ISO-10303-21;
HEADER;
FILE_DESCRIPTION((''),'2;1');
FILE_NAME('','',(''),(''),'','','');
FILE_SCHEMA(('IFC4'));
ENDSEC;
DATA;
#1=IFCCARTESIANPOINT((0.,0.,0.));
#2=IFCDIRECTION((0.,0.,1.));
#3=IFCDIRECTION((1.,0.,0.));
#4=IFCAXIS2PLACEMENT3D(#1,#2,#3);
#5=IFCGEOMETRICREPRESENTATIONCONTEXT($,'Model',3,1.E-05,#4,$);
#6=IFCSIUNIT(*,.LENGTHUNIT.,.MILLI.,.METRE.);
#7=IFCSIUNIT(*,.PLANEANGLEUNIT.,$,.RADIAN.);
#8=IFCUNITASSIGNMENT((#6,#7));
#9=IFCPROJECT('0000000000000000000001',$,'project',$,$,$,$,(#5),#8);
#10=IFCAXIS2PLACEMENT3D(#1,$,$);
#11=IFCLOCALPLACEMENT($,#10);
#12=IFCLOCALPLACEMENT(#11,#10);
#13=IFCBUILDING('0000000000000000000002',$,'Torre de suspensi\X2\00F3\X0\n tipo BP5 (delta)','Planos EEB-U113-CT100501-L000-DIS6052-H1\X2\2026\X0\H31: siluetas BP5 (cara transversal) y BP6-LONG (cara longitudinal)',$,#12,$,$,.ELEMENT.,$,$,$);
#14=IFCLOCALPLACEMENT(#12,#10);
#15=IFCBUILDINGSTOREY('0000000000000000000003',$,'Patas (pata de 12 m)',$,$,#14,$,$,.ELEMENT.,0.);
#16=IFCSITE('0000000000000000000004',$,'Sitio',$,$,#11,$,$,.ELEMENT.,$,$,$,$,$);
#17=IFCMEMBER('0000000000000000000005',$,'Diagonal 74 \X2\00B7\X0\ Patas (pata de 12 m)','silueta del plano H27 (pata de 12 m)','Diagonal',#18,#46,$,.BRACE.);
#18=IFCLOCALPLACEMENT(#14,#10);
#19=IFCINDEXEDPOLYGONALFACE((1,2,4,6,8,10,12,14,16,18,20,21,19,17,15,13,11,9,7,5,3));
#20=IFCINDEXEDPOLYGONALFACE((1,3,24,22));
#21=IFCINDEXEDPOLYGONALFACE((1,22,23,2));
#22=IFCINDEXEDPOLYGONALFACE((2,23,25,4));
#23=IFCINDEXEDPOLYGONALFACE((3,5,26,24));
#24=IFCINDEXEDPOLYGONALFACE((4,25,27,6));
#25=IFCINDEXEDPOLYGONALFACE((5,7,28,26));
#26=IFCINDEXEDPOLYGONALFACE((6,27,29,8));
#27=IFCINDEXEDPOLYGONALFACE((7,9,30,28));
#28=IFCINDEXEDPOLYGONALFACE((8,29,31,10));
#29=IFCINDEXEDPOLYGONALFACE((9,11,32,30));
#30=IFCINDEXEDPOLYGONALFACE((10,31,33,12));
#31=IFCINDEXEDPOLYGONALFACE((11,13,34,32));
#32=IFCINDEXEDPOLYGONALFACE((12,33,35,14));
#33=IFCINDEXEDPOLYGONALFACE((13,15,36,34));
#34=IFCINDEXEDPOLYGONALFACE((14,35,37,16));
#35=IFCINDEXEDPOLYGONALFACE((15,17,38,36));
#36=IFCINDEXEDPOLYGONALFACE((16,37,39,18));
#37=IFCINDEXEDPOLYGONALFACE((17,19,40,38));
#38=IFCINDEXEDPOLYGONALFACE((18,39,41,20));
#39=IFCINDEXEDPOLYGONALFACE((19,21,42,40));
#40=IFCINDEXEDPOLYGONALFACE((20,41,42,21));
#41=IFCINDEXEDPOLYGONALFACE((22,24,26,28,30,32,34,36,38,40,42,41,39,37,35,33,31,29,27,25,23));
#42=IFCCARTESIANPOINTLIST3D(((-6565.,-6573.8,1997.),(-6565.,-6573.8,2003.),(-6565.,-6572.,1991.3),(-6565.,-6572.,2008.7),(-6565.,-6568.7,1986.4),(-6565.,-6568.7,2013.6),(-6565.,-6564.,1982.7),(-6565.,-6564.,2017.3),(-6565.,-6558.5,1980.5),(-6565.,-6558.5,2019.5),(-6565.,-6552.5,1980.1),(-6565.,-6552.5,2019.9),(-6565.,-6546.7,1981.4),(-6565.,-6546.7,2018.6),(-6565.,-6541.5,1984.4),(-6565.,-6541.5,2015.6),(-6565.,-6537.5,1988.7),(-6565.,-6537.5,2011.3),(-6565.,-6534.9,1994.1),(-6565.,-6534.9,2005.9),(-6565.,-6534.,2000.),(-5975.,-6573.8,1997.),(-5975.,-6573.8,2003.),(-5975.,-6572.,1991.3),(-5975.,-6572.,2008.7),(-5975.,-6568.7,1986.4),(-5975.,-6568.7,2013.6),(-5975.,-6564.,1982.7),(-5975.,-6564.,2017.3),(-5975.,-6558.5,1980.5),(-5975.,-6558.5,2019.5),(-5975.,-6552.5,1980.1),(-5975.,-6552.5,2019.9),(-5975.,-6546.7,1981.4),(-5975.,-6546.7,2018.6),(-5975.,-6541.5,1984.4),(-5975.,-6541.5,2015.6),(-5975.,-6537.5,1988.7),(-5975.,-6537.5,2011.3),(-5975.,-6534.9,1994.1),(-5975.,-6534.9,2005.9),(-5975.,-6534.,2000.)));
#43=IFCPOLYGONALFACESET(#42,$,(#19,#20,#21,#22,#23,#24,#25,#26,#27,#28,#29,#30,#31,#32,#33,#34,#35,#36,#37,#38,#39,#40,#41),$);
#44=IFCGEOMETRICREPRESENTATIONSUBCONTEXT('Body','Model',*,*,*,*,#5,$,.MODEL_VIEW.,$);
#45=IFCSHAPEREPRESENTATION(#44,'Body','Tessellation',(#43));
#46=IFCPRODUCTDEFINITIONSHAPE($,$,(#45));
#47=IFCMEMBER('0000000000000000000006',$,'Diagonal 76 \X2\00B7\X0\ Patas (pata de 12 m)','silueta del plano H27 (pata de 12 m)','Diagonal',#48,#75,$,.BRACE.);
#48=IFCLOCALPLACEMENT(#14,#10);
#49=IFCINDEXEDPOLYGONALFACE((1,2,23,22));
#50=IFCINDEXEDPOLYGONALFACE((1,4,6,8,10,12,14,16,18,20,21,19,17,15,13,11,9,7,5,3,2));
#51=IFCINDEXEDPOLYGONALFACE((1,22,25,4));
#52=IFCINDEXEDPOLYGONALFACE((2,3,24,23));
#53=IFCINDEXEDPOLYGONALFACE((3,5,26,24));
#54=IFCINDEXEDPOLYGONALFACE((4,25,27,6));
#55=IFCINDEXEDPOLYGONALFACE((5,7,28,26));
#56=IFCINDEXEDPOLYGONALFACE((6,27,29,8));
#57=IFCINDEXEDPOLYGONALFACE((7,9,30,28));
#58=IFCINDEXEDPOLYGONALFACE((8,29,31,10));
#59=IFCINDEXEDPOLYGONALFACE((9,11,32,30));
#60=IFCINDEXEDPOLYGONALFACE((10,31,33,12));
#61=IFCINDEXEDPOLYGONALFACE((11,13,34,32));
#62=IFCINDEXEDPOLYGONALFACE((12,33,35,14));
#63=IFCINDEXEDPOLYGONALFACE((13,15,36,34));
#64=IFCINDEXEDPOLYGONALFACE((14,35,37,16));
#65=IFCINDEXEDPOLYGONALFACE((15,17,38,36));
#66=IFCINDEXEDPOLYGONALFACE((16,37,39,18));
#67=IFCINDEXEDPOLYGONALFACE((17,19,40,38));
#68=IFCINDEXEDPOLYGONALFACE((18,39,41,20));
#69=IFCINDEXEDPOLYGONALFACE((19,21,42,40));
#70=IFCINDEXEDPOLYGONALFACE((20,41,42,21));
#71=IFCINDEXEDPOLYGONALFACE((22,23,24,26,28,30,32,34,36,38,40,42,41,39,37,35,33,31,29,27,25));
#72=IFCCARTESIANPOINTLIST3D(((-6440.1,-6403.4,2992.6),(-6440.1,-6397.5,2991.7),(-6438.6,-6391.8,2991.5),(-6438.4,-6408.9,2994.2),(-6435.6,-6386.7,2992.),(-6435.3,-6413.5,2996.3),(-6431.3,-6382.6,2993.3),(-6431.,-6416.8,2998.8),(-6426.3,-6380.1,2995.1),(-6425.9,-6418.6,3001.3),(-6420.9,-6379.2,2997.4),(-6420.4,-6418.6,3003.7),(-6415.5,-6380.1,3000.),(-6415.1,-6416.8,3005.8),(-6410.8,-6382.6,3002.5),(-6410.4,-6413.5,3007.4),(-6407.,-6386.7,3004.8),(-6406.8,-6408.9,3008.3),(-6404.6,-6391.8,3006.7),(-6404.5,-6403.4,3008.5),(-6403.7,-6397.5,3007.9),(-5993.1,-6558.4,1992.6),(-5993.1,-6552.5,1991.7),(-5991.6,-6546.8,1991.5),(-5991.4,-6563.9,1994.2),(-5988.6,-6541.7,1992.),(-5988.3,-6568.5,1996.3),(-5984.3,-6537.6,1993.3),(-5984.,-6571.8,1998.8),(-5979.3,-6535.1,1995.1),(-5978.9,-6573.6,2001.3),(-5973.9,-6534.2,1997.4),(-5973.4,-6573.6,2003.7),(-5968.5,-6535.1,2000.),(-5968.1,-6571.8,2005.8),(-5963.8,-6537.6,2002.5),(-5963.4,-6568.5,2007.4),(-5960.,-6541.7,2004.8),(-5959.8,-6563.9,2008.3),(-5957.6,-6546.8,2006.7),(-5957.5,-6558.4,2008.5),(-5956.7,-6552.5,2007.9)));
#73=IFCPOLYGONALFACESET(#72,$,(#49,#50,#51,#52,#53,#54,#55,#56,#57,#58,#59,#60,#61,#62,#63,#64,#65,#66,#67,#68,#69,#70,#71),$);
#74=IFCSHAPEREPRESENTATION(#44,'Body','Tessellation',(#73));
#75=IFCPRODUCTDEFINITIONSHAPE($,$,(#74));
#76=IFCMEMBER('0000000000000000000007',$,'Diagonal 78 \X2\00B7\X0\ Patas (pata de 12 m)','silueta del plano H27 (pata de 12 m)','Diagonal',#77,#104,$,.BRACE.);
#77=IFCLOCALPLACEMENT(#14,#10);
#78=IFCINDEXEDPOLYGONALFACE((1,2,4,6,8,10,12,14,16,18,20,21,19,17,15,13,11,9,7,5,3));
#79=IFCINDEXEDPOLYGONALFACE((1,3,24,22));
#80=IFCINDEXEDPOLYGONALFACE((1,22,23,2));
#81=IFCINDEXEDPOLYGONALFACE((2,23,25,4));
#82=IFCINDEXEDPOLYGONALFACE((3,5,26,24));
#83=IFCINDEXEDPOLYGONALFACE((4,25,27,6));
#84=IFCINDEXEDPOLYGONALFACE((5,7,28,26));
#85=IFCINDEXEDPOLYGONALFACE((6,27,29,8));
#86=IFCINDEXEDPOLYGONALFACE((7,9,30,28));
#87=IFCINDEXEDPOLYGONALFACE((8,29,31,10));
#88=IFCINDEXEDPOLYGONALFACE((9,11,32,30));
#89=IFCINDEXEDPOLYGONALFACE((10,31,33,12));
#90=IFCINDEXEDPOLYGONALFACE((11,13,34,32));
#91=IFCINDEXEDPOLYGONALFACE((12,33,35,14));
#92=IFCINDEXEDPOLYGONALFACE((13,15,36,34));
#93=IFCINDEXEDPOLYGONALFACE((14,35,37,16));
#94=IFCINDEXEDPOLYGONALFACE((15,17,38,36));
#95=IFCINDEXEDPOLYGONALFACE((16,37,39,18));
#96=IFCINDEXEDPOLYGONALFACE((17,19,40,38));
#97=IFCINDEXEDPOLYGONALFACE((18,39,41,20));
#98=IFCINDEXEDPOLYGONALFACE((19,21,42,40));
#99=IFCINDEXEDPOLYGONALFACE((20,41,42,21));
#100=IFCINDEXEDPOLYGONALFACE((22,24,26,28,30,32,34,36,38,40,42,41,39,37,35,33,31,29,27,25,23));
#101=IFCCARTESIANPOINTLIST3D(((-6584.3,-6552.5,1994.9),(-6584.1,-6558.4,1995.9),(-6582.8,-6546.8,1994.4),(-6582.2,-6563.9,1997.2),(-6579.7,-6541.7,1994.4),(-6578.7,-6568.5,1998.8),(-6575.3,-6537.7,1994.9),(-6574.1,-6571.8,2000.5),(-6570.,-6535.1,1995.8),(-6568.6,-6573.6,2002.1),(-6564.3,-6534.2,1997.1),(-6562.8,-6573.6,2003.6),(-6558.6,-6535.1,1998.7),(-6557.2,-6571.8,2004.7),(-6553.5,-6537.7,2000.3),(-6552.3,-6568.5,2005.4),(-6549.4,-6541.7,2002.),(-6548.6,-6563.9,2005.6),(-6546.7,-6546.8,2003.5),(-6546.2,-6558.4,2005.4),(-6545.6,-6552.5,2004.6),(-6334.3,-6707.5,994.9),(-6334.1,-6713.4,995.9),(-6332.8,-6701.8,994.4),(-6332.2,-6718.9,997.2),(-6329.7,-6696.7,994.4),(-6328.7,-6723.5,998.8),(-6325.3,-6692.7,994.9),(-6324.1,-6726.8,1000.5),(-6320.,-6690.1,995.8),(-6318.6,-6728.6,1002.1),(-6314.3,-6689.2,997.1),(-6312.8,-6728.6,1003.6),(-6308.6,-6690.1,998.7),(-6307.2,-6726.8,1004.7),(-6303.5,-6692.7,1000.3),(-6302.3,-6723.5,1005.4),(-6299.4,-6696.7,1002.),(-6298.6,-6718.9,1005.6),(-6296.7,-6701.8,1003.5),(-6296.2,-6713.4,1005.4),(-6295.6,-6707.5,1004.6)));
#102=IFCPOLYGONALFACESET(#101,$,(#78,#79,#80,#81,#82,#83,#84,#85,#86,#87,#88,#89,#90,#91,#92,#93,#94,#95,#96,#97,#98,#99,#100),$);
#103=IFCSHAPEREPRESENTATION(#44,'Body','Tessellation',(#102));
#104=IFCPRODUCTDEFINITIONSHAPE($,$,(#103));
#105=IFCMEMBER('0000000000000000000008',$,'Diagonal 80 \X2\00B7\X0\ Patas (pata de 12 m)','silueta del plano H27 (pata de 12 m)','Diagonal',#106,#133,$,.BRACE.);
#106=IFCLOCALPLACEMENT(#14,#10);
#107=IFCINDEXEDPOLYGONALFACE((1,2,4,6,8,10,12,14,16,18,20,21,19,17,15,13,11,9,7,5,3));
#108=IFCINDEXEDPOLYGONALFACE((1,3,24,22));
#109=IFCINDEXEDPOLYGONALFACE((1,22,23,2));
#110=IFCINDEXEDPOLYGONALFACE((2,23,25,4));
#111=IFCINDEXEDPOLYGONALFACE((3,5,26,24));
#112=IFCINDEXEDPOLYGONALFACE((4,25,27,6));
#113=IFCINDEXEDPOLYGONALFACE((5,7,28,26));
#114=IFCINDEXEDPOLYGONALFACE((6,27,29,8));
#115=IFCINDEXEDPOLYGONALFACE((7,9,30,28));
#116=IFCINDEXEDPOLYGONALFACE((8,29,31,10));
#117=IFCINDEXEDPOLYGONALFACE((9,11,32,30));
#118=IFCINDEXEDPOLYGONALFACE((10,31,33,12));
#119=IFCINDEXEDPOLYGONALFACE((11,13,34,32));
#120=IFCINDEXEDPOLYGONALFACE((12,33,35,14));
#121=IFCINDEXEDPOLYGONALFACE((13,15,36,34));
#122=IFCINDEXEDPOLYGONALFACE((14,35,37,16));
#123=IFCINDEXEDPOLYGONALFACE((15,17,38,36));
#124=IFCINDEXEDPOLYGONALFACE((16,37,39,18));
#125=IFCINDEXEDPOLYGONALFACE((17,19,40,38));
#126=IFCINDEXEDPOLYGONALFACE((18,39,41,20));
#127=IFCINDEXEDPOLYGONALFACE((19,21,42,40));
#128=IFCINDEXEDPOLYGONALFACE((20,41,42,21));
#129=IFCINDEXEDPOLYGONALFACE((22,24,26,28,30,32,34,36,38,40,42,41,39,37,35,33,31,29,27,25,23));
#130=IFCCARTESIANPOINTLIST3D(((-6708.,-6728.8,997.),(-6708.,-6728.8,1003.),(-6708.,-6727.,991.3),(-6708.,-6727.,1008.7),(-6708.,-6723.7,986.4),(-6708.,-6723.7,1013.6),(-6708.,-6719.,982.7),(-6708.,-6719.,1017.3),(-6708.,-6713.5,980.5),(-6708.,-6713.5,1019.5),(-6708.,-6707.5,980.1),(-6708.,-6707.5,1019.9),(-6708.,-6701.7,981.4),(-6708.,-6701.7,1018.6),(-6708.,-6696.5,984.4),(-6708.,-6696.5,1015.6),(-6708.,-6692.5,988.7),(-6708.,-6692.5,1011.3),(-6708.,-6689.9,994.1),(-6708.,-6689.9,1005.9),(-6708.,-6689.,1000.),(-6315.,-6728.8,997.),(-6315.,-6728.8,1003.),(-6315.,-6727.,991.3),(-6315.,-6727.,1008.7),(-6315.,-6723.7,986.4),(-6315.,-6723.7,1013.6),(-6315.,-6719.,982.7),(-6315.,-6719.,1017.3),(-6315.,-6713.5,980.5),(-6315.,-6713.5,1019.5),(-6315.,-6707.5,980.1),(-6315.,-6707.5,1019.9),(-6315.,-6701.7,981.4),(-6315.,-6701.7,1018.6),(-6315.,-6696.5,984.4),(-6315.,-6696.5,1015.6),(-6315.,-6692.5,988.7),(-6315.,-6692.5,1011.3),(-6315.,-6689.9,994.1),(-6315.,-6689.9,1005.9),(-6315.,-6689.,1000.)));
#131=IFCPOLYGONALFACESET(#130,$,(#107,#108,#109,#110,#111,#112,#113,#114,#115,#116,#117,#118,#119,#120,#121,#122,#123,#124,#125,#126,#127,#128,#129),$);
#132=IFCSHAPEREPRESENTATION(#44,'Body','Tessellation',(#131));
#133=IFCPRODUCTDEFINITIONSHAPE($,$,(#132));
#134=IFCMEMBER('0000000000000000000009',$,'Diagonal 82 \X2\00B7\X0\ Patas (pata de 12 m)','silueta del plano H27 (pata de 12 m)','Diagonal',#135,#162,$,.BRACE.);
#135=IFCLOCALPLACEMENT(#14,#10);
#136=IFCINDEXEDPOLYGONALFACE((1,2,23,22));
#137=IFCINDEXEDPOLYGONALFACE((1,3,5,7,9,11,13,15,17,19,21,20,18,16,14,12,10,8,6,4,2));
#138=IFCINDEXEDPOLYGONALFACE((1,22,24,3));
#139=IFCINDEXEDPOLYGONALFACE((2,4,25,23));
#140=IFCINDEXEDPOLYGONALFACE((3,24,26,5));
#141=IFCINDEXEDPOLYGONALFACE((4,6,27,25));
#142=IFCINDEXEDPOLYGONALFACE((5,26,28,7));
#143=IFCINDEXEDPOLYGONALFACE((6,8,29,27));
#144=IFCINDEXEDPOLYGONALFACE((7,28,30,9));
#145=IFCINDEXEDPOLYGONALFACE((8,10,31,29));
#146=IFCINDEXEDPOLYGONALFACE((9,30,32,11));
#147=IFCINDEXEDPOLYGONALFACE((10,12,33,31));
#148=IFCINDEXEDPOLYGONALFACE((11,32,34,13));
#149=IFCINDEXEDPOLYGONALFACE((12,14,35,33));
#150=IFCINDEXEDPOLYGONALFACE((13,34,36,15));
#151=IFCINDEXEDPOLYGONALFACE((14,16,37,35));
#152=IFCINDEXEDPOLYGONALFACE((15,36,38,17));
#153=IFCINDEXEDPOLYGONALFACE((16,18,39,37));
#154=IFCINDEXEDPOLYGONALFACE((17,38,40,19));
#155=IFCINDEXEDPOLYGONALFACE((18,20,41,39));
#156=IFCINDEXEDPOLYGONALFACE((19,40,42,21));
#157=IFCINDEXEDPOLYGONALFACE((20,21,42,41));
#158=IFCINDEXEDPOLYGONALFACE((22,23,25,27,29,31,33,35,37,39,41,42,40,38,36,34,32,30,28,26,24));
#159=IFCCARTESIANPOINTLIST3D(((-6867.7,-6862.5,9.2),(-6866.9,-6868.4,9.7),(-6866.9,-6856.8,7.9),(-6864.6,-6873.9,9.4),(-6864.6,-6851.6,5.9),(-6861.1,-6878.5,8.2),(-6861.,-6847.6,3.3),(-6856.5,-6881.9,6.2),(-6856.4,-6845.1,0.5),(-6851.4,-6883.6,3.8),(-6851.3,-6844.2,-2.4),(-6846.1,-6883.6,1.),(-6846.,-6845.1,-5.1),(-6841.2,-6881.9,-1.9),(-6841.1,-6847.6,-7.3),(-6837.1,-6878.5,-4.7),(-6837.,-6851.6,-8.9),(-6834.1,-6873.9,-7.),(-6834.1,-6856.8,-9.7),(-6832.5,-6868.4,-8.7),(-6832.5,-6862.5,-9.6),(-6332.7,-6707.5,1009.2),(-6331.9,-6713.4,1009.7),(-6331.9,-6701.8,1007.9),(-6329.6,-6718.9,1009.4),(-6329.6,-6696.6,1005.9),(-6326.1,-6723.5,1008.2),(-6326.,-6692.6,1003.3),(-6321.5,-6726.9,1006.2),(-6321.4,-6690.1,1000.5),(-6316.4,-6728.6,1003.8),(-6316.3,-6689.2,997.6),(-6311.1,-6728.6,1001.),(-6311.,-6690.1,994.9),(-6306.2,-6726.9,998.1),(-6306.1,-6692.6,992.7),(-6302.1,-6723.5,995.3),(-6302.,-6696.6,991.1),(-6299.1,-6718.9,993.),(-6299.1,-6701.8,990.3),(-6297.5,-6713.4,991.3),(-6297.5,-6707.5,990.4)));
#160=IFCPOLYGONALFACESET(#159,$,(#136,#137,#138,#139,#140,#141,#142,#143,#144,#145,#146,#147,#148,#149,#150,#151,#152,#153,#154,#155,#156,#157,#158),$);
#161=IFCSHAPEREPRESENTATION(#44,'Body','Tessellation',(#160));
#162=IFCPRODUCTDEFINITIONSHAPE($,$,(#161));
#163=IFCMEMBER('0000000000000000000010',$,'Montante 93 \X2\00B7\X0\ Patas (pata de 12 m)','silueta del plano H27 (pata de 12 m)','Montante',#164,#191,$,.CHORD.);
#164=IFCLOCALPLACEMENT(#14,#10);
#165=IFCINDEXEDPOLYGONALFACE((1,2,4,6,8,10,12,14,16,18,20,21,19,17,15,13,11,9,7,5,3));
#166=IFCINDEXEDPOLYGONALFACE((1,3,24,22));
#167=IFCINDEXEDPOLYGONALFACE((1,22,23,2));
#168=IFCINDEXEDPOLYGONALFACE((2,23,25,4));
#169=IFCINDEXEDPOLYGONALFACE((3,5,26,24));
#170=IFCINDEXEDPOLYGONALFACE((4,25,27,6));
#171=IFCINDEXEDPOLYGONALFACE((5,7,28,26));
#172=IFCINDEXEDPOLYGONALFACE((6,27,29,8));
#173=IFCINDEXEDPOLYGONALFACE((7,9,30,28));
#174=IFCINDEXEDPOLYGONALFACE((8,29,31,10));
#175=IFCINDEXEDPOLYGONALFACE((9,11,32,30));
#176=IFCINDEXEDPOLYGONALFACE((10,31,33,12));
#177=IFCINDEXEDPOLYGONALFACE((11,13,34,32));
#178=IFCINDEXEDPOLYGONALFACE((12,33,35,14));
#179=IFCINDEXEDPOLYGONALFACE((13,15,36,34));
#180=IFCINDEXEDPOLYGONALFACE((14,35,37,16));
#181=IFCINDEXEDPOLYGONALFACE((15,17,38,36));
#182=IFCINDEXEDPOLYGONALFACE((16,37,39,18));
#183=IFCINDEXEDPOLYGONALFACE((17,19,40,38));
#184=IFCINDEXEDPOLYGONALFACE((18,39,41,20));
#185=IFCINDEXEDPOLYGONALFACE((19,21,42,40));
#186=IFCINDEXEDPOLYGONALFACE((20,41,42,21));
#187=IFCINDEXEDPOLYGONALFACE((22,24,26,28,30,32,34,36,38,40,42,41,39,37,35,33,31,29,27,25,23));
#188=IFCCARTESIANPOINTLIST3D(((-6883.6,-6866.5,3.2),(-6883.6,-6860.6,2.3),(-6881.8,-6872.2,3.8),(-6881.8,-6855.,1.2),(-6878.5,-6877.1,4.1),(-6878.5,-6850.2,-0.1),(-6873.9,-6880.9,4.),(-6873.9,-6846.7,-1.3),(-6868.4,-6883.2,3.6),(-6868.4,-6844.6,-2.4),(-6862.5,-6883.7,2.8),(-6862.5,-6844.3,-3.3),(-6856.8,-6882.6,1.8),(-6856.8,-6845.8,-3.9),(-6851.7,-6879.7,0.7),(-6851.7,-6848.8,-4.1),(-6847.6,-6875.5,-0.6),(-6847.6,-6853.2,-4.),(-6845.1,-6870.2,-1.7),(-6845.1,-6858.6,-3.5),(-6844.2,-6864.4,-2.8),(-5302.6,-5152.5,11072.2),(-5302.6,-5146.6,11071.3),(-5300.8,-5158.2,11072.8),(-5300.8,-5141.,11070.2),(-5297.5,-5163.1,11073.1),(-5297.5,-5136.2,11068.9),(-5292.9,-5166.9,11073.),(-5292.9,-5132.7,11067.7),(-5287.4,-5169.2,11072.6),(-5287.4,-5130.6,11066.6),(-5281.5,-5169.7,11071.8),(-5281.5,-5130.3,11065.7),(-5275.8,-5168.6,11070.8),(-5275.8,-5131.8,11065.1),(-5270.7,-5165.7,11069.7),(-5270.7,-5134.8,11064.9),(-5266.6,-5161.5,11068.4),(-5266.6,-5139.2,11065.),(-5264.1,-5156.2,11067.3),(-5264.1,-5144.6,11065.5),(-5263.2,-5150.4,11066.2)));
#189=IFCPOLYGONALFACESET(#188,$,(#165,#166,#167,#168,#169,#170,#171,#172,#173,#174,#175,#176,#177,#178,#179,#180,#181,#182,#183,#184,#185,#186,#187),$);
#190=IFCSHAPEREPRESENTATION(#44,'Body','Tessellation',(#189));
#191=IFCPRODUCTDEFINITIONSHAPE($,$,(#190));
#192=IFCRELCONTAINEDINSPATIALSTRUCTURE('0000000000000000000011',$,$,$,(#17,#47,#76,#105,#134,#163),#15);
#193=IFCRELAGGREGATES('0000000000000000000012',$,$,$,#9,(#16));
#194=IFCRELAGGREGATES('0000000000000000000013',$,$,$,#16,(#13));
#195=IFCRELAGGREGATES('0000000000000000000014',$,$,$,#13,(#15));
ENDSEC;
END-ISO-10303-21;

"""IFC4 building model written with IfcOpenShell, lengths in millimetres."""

from ifc_helpers import new_model, si_unit, frame, origin, origin_with_axes, place, context, subcontext, project, spatial, circle, extrude, element, save


model = new_model("IFC4")

# Units and contexts
model_context = context("Model", 3, precision=1e-05, world=origin_with_axes())
body_context = subcontext(model_context, "Body", "Model", "MODEL_VIEW")
ifc_project = project(units=[si_unit("LENGTHUNIT", "METRE", prefix="MILLI"), si_unit("PLANEANGLEUNIT", "RADIAN")], contexts=[model_context])

# Site, building, storey
site_placement = place(None, origin())
site = spatial("IfcSite", under=ifc_project, at=site_placement, Name="Sitio", CompositionType="ELEMENT")
building_placement = place(site_placement, origin())
building = spatial("IfcBuilding", under=site, at=building_placement, Name="Torre de suspensión tipo BP5 (delta)", Description="Planos EEB-U113-CT100501-L000-DIS6052-H1…H31: siluetas BP5 (cara transversal) y BP6-LONG (cara longitudinal)", CompositionType="ELEMENT")
storey_placement = place(building_placement, origin())
storey = spatial("IfcBuildingStorey", under=building, at=storey_placement, Name="Patas (pata de 12 m)", CompositionType="ELEMENT", Elevation=0.0)

# Members
member_1_placement = place(storey_placement, frame((-6565.0, -6554.0, 2000.0), z_axis=(1.0, 0.0, 0.0), x_axis=(0.0, 1.0, 0.0)))
element("IfcMember", 1, at=member_1_placement, inside=storey, Name="Diagonal 74 · Patas (pata de 12 m)", Description="silueta del plano H27 (pata de 12 m)", ObjectType="Diagonal", PredefinedType="BRACE", context=body_context, shape_type="SweptSolid", body=[
    extrude(circle(Radius=20.0), None, (0.0, 0.0, 1.0), 590.0),
])
member_2_placement = place(storey_placement, frame((-5975.0, -6554.0, 2000.0), z_axis=(-0.40406, 0.14011, 0.903938), x_axis=(0.057177, 0.990136, -0.127913)))
element("IfcMember", 2, at=member_2_placement, inside=storey, Name="Diagonal 76 · Patas (pata de 12 m)", Description="silueta del plano H27 (pata de 12 m)", ObjectType="Diagonal", PredefinedType="BRACE", context=body_context, shape_type="SweptSolid", body=[
    extrude(circle(Radius=20.0), None, (0.0, 0.0, 1.0), 1106.3),
])
member_3_placement = place(storey_placement, frame((-6315.0, -6709.0, 1000.0), z_axis=(-0.239839, 0.1487, 0.959357), x_axis=(0.036065, 0.988882, -0.14426)))
element("IfcMember", 3, at=member_3_placement, inside=storey, Name="Diagonal 78 · Patas (pata de 12 m)", Description="silueta del plano H27 (pata de 12 m)", ObjectType="Diagonal", PredefinedType="BRACE", context=body_context, shape_type="SweptSolid", body=[
    extrude(circle(Radius=20.0), None, (0.0, 0.0, 1.0), 1042.4),
])
member_4_placement = place(storey_placement, frame((-6708.0, -6709.0, 1000.0), z_axis=(1.0, 0.0, 0.0), x_axis=(0.0, 1.0, 0.0)))
element("IfcMember", 4, at=member_4_placement, inside=storey, Name="Diagonal 80 · Patas (pata de 12 m)", Description="silueta del plano H27 (pata de 12 m)", ObjectType="Diagonal", PredefinedType="BRACE", context=body_context, shape_type="SweptSolid", body=[
    extrude(circle(Radius=20.0), None, (0.0, 0.0, 1.0), 393.0),
])
member_5_placement = place(storey_placement, frame((-6850.0, -6864.0, 0.0), z_axis=(0.467387, 0.135411, 0.873621), x_axis=(-0.063878, 0.990789, -0.119398)))
element("IfcMember", 5, at=member_5_placement, inside=storey, Name="Diagonal 82 · Patas (pata de 12 m)", Description="silueta del plano H27 (pata de 12 m)", ObjectType="Diagonal", PredefinedType="BRACE", context=body_context, shape_type="SweptSolid", body=[
    extrude(circle(Radius=20.0), None, (0.0, 0.0, 1.0), 1144.7),
])
member_6_placement = place(storey_placement, frame((-6864.0, -6864.0, 0.0), z_axis=(0.139764, 0.151521, 0.978523), x_axis=(0.990185, -0.021387, -0.138118)))
element("IfcMember", 6, at=member_6_placement, inside=storey, Name="Montante 93 · Patas (pata de 12 m)", Description="silueta del plano H27 (pata de 12 m)", ObjectType="Montante", PredefinedType="CHORD", context=body_context, shape_type="SweptSolid", body=[
    extrude(circle(Radius=20.0), None, (0.0, 0.0, 1.0), 11311.9),
])

save(model, "model.ifc")
